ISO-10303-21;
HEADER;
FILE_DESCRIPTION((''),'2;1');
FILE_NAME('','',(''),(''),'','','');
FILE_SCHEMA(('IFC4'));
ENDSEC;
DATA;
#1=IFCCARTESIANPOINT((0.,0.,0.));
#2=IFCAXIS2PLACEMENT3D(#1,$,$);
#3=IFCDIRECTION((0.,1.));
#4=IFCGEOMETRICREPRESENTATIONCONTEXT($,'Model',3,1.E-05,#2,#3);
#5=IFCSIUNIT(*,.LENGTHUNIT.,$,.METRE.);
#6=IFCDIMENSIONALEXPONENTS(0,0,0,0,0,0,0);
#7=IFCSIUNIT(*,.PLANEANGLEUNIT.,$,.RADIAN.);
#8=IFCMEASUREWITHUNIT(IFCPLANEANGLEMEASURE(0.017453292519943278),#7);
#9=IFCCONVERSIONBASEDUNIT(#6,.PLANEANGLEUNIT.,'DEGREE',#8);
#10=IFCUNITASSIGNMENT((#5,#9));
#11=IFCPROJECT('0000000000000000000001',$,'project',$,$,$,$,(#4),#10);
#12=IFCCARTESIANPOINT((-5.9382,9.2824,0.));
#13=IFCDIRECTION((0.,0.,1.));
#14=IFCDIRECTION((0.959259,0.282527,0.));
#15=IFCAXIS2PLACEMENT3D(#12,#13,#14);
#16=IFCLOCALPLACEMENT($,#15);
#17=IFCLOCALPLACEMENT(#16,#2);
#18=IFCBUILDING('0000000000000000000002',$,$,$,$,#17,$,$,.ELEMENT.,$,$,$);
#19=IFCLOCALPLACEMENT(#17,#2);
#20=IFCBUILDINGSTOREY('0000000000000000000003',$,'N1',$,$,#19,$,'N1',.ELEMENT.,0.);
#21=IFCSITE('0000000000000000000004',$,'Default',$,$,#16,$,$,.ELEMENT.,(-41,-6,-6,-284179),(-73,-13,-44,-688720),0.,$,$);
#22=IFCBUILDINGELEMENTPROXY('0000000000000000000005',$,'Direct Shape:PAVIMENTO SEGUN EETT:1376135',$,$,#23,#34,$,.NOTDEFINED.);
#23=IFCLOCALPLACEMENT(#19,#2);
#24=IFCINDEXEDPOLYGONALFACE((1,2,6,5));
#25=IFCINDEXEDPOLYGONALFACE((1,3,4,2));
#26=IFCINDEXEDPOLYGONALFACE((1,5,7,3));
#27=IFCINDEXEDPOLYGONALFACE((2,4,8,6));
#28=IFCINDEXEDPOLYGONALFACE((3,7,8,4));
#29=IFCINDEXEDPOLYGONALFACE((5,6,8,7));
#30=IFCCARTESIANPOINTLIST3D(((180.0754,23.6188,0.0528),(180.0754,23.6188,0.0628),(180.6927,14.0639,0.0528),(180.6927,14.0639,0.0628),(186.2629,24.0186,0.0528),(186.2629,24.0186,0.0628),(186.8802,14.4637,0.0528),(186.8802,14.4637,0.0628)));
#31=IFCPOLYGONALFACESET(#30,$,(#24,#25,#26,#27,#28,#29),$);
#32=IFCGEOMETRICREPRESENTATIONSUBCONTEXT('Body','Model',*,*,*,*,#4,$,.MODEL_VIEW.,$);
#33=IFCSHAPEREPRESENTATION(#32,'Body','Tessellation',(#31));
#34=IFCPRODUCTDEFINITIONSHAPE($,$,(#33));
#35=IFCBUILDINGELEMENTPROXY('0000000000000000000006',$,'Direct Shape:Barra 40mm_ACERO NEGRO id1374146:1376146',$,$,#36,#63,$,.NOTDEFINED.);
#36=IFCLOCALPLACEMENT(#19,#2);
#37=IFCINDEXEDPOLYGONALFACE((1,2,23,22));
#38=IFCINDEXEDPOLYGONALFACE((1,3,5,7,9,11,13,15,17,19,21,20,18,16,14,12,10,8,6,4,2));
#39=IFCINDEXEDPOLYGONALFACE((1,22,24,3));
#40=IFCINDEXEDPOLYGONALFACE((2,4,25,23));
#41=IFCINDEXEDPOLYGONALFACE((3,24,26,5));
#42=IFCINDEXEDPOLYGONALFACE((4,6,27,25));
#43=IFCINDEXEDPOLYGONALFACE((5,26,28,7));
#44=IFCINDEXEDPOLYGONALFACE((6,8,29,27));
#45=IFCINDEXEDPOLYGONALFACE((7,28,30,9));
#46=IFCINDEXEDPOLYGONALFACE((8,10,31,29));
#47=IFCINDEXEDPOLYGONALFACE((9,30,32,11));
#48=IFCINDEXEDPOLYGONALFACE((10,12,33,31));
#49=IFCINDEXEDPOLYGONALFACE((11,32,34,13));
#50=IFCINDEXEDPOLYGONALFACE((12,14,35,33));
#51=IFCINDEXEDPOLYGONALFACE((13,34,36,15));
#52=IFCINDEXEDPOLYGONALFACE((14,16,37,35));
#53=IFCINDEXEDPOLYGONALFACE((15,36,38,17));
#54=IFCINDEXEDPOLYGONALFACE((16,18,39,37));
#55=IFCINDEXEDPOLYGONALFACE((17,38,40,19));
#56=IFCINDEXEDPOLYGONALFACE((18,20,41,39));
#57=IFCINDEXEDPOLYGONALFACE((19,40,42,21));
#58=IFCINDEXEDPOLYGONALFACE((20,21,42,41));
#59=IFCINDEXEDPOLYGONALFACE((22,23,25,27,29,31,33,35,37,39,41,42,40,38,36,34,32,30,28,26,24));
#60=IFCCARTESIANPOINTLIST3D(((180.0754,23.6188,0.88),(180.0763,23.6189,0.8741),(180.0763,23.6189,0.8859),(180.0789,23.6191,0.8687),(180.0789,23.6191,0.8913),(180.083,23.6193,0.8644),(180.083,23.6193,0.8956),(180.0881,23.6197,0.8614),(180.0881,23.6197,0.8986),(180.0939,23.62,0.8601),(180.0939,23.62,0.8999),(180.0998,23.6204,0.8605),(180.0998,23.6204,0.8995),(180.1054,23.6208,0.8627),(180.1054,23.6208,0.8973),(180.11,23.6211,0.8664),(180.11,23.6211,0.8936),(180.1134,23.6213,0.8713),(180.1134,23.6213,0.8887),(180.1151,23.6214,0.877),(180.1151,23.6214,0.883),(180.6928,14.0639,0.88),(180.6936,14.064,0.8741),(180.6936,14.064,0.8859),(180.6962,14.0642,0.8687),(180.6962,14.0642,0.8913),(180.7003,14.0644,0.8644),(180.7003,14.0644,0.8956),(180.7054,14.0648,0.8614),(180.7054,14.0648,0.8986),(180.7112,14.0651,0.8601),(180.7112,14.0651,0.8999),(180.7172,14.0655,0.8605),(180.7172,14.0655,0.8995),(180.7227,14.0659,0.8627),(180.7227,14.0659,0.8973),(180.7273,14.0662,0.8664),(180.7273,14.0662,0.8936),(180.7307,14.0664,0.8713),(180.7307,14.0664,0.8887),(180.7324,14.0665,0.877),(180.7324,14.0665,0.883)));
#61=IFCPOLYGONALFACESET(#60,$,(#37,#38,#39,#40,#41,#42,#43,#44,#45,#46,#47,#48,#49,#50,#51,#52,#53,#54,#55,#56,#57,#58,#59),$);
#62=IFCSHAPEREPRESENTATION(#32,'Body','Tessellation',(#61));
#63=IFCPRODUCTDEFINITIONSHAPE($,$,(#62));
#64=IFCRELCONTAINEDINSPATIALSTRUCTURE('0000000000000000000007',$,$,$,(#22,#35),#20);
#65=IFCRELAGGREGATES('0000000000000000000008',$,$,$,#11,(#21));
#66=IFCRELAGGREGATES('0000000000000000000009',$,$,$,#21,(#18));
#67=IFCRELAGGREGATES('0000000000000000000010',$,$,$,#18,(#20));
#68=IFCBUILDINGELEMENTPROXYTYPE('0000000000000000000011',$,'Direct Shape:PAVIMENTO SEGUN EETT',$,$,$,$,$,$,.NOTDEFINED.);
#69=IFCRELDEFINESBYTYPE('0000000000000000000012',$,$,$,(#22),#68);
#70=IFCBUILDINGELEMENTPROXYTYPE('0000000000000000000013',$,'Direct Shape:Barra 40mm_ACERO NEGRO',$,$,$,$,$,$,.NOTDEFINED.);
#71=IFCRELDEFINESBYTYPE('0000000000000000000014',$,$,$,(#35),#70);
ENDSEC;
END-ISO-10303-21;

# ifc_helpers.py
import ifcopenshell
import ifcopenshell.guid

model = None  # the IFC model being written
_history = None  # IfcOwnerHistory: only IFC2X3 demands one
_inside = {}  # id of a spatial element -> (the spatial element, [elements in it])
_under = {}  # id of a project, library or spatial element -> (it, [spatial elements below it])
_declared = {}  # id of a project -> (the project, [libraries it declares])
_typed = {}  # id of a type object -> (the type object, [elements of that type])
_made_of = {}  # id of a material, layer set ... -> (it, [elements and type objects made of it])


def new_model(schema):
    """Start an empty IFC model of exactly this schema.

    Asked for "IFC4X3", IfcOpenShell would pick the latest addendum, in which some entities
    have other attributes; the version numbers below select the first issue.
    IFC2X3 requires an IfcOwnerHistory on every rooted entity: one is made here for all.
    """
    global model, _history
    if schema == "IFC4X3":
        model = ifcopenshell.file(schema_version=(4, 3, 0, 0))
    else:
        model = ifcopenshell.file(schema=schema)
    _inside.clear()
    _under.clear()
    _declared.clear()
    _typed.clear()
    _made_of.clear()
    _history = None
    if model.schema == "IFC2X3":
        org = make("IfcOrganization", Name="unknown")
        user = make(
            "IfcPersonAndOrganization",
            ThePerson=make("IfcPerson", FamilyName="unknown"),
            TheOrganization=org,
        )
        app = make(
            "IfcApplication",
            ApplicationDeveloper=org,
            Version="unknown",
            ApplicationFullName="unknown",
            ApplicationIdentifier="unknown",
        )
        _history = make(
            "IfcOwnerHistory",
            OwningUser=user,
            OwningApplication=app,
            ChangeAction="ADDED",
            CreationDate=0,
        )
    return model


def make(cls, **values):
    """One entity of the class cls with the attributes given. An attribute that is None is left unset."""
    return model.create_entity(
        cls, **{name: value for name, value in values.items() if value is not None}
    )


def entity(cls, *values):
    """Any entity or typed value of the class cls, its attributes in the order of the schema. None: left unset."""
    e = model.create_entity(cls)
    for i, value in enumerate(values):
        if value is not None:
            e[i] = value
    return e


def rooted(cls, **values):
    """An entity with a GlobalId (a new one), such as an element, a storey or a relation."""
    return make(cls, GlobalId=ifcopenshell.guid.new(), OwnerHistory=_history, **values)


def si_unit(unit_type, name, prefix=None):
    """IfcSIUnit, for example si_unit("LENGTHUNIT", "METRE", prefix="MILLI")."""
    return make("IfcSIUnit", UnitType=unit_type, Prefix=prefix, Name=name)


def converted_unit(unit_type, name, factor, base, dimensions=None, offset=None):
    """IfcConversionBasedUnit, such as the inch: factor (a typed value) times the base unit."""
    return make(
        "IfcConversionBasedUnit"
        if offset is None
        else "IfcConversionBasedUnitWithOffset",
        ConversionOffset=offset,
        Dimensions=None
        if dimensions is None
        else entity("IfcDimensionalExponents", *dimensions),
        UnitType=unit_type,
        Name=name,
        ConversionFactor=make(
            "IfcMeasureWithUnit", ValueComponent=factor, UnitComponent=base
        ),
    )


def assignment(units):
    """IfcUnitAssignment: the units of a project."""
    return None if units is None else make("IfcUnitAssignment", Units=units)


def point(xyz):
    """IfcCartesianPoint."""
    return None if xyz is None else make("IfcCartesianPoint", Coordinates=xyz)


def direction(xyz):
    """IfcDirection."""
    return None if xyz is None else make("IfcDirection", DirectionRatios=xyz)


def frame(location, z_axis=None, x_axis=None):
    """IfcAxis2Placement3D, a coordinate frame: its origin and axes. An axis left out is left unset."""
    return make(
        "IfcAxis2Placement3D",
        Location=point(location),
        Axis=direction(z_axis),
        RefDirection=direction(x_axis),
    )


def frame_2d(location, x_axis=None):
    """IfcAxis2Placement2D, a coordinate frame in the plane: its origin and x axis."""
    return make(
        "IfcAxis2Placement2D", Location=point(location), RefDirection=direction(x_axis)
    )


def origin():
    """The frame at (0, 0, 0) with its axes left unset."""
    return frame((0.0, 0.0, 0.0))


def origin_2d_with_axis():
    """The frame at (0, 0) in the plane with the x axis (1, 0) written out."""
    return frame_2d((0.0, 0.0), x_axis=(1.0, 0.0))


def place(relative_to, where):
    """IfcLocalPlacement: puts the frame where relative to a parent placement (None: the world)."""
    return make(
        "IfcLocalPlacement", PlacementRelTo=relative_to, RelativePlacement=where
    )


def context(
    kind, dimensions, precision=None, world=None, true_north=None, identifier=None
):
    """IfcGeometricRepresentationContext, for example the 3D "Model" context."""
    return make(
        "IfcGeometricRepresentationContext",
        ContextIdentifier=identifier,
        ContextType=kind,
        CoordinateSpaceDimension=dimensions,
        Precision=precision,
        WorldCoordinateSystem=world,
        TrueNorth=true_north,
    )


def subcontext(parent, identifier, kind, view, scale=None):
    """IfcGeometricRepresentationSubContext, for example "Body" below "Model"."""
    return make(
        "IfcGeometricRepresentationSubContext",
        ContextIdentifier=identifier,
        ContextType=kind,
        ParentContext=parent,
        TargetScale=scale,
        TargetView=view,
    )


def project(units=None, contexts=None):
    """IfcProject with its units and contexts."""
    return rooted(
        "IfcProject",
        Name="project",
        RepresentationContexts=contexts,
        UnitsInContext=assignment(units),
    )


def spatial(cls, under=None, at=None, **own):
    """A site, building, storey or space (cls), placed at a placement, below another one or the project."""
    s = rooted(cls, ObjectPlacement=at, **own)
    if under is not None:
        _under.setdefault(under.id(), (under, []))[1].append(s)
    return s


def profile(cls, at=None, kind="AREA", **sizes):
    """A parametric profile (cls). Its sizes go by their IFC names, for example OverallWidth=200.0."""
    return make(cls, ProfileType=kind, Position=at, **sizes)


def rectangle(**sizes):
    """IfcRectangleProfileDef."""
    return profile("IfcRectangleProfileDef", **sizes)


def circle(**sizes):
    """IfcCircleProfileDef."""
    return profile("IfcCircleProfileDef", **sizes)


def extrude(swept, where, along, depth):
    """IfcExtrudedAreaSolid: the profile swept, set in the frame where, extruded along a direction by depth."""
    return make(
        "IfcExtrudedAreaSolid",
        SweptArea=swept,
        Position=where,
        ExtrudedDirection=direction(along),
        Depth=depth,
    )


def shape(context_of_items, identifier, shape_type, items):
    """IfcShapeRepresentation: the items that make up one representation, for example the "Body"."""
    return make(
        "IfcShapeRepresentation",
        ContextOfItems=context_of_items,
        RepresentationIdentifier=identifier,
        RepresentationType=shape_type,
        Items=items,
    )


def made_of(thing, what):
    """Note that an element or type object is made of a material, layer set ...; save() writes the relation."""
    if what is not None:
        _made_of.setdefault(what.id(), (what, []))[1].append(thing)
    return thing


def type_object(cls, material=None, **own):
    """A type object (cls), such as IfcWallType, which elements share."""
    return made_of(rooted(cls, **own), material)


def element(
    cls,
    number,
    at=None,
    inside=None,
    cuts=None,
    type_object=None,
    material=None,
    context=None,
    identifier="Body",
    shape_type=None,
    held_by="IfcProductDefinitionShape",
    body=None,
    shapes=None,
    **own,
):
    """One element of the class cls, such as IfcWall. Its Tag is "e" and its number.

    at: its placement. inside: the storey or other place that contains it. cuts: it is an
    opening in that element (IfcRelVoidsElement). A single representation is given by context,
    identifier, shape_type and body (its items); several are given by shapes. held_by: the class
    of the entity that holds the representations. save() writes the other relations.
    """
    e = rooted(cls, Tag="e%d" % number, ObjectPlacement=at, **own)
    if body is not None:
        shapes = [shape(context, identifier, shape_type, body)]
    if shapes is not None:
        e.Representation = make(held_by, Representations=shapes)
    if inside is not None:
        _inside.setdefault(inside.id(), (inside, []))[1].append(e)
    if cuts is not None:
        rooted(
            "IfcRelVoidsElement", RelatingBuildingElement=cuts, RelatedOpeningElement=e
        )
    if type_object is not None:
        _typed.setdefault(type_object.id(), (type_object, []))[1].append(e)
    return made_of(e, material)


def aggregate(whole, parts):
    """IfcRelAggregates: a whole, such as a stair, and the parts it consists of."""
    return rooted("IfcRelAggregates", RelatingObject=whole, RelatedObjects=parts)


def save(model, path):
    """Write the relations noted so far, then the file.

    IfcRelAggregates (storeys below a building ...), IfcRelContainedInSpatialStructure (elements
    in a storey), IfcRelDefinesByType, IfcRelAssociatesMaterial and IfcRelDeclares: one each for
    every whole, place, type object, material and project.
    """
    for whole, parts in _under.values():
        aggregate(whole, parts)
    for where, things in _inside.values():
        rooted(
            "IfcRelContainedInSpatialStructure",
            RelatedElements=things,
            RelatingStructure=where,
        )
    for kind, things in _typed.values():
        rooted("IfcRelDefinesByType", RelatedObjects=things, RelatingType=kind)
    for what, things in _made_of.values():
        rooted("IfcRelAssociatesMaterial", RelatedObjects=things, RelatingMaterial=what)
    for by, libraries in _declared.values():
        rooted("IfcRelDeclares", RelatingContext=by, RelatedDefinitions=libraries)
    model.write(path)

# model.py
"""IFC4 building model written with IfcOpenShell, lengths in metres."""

from ifc_helpers import new_model, entity, si_unit, converted_unit, direction, frame, frame_2d, origin, origin_2d_with_axis, place, context, subcontext, project, spatial, rectangle, circle, extrude, type_object, element, save


model = new_model("IFC4")

# Units and contexts
model_context = context("Model", 3, precision=1e-05, world=origin(), true_north=direction((0.0, 1.0)))
body_context = subcontext(model_context, "Body", "Model", "MODEL_VIEW")
ifc_project = project(units=[si_unit("LENGTHUNIT", "METRE"), converted_unit("PLANEANGLEUNIT", "DEGREE", entity("IfcPlaneAngleMeasure", 0.017453292519943278), si_unit("PLANEANGLEUNIT", "RADIAN"), dimensions=[0, 0, 0, 0, 0, 0, 0])], contexts=[model_context])

# Site, building, storey
site_placement = place(None, frame((-5.9382, 9.2824, 0.0), z_axis=(0.0, 0.0, 1.0), x_axis=(0.959259, 0.282527, 0.0)))
site = spatial("IfcSite", under=ifc_project, at=site_placement, Name="Default", CompositionType="ELEMENT", RefLatitude=(-41, -6, -6, -284179), RefLongitude=(-73, -13, -44, -688720), RefElevation=0.0)
building_placement = place(site_placement, origin())
building = spatial("IfcBuilding", under=site, at=building_placement, CompositionType="ELEMENT")
storey_placement = place(building_placement, origin())
storey = spatial("IfcBuildingStorey", under=building, at=storey_placement, Name="N1", LongName="N1", CompositionType="ELEMENT", Elevation=0.0)

# Building element proxies
building_element_proxy_type_1 = type_object("IfcBuildingElementProxyType", Name="Direct Shape:PAVIMENTO SEGUN EETT", PredefinedType="NOTDEFINED")
proxy_1_placement = place(storey_placement, origin())
element("IfcBuildingElementProxy", 1, at=proxy_1_placement, inside=storey, type_object=building_element_proxy_type_1, Name="Direct Shape:PAVIMENTO SEGUN EETT:1376135", PredefinedType="NOTDEFINED", context=body_context, shape_type="SweptSolid", body=[
    extrude(rectangle(XDim=9.5748, YDim=6.2004, at=origin_2d_with_axis()), frame((183.4778, 19.0413, 0.0528), z_axis=(0.0, 0.0, 1.0), x_axis=(-0.064471, 0.99792, 0.0)), (0.0, 0.0, 1.0), 0.01),
])
building_element_proxy_type_2 = type_object("IfcBuildingElementProxyType", Name="Direct Shape:Barra 40mm_ACERO NEGRO", PredefinedType="NOTDEFINED")
proxy_2_placement = place(storey_placement, origin())
element("IfcBuildingElementProxy", 2, at=proxy_2_placement, inside=storey, type_object=building_element_proxy_type_2, Name="Direct Shape:Barra 40mm_ACERO NEGRO id1374146:1376146", PredefinedType="NOTDEFINED", context=body_context, shape_type="SweptSolid", body=[
    extrude(circle(Radius=0.02, at=frame_2d((0.0, 0.0), x_axis=(1.0, 0.0))), frame((180.7127, 14.0652, 0.88), z_axis=(-0.064471, 0.99792, 0.0), x_axis=(-0.99792, -0.064471, 0.0)), (0.0, 0.0, 1.0), 9.5748),
])

save(model, "model.ifc")
